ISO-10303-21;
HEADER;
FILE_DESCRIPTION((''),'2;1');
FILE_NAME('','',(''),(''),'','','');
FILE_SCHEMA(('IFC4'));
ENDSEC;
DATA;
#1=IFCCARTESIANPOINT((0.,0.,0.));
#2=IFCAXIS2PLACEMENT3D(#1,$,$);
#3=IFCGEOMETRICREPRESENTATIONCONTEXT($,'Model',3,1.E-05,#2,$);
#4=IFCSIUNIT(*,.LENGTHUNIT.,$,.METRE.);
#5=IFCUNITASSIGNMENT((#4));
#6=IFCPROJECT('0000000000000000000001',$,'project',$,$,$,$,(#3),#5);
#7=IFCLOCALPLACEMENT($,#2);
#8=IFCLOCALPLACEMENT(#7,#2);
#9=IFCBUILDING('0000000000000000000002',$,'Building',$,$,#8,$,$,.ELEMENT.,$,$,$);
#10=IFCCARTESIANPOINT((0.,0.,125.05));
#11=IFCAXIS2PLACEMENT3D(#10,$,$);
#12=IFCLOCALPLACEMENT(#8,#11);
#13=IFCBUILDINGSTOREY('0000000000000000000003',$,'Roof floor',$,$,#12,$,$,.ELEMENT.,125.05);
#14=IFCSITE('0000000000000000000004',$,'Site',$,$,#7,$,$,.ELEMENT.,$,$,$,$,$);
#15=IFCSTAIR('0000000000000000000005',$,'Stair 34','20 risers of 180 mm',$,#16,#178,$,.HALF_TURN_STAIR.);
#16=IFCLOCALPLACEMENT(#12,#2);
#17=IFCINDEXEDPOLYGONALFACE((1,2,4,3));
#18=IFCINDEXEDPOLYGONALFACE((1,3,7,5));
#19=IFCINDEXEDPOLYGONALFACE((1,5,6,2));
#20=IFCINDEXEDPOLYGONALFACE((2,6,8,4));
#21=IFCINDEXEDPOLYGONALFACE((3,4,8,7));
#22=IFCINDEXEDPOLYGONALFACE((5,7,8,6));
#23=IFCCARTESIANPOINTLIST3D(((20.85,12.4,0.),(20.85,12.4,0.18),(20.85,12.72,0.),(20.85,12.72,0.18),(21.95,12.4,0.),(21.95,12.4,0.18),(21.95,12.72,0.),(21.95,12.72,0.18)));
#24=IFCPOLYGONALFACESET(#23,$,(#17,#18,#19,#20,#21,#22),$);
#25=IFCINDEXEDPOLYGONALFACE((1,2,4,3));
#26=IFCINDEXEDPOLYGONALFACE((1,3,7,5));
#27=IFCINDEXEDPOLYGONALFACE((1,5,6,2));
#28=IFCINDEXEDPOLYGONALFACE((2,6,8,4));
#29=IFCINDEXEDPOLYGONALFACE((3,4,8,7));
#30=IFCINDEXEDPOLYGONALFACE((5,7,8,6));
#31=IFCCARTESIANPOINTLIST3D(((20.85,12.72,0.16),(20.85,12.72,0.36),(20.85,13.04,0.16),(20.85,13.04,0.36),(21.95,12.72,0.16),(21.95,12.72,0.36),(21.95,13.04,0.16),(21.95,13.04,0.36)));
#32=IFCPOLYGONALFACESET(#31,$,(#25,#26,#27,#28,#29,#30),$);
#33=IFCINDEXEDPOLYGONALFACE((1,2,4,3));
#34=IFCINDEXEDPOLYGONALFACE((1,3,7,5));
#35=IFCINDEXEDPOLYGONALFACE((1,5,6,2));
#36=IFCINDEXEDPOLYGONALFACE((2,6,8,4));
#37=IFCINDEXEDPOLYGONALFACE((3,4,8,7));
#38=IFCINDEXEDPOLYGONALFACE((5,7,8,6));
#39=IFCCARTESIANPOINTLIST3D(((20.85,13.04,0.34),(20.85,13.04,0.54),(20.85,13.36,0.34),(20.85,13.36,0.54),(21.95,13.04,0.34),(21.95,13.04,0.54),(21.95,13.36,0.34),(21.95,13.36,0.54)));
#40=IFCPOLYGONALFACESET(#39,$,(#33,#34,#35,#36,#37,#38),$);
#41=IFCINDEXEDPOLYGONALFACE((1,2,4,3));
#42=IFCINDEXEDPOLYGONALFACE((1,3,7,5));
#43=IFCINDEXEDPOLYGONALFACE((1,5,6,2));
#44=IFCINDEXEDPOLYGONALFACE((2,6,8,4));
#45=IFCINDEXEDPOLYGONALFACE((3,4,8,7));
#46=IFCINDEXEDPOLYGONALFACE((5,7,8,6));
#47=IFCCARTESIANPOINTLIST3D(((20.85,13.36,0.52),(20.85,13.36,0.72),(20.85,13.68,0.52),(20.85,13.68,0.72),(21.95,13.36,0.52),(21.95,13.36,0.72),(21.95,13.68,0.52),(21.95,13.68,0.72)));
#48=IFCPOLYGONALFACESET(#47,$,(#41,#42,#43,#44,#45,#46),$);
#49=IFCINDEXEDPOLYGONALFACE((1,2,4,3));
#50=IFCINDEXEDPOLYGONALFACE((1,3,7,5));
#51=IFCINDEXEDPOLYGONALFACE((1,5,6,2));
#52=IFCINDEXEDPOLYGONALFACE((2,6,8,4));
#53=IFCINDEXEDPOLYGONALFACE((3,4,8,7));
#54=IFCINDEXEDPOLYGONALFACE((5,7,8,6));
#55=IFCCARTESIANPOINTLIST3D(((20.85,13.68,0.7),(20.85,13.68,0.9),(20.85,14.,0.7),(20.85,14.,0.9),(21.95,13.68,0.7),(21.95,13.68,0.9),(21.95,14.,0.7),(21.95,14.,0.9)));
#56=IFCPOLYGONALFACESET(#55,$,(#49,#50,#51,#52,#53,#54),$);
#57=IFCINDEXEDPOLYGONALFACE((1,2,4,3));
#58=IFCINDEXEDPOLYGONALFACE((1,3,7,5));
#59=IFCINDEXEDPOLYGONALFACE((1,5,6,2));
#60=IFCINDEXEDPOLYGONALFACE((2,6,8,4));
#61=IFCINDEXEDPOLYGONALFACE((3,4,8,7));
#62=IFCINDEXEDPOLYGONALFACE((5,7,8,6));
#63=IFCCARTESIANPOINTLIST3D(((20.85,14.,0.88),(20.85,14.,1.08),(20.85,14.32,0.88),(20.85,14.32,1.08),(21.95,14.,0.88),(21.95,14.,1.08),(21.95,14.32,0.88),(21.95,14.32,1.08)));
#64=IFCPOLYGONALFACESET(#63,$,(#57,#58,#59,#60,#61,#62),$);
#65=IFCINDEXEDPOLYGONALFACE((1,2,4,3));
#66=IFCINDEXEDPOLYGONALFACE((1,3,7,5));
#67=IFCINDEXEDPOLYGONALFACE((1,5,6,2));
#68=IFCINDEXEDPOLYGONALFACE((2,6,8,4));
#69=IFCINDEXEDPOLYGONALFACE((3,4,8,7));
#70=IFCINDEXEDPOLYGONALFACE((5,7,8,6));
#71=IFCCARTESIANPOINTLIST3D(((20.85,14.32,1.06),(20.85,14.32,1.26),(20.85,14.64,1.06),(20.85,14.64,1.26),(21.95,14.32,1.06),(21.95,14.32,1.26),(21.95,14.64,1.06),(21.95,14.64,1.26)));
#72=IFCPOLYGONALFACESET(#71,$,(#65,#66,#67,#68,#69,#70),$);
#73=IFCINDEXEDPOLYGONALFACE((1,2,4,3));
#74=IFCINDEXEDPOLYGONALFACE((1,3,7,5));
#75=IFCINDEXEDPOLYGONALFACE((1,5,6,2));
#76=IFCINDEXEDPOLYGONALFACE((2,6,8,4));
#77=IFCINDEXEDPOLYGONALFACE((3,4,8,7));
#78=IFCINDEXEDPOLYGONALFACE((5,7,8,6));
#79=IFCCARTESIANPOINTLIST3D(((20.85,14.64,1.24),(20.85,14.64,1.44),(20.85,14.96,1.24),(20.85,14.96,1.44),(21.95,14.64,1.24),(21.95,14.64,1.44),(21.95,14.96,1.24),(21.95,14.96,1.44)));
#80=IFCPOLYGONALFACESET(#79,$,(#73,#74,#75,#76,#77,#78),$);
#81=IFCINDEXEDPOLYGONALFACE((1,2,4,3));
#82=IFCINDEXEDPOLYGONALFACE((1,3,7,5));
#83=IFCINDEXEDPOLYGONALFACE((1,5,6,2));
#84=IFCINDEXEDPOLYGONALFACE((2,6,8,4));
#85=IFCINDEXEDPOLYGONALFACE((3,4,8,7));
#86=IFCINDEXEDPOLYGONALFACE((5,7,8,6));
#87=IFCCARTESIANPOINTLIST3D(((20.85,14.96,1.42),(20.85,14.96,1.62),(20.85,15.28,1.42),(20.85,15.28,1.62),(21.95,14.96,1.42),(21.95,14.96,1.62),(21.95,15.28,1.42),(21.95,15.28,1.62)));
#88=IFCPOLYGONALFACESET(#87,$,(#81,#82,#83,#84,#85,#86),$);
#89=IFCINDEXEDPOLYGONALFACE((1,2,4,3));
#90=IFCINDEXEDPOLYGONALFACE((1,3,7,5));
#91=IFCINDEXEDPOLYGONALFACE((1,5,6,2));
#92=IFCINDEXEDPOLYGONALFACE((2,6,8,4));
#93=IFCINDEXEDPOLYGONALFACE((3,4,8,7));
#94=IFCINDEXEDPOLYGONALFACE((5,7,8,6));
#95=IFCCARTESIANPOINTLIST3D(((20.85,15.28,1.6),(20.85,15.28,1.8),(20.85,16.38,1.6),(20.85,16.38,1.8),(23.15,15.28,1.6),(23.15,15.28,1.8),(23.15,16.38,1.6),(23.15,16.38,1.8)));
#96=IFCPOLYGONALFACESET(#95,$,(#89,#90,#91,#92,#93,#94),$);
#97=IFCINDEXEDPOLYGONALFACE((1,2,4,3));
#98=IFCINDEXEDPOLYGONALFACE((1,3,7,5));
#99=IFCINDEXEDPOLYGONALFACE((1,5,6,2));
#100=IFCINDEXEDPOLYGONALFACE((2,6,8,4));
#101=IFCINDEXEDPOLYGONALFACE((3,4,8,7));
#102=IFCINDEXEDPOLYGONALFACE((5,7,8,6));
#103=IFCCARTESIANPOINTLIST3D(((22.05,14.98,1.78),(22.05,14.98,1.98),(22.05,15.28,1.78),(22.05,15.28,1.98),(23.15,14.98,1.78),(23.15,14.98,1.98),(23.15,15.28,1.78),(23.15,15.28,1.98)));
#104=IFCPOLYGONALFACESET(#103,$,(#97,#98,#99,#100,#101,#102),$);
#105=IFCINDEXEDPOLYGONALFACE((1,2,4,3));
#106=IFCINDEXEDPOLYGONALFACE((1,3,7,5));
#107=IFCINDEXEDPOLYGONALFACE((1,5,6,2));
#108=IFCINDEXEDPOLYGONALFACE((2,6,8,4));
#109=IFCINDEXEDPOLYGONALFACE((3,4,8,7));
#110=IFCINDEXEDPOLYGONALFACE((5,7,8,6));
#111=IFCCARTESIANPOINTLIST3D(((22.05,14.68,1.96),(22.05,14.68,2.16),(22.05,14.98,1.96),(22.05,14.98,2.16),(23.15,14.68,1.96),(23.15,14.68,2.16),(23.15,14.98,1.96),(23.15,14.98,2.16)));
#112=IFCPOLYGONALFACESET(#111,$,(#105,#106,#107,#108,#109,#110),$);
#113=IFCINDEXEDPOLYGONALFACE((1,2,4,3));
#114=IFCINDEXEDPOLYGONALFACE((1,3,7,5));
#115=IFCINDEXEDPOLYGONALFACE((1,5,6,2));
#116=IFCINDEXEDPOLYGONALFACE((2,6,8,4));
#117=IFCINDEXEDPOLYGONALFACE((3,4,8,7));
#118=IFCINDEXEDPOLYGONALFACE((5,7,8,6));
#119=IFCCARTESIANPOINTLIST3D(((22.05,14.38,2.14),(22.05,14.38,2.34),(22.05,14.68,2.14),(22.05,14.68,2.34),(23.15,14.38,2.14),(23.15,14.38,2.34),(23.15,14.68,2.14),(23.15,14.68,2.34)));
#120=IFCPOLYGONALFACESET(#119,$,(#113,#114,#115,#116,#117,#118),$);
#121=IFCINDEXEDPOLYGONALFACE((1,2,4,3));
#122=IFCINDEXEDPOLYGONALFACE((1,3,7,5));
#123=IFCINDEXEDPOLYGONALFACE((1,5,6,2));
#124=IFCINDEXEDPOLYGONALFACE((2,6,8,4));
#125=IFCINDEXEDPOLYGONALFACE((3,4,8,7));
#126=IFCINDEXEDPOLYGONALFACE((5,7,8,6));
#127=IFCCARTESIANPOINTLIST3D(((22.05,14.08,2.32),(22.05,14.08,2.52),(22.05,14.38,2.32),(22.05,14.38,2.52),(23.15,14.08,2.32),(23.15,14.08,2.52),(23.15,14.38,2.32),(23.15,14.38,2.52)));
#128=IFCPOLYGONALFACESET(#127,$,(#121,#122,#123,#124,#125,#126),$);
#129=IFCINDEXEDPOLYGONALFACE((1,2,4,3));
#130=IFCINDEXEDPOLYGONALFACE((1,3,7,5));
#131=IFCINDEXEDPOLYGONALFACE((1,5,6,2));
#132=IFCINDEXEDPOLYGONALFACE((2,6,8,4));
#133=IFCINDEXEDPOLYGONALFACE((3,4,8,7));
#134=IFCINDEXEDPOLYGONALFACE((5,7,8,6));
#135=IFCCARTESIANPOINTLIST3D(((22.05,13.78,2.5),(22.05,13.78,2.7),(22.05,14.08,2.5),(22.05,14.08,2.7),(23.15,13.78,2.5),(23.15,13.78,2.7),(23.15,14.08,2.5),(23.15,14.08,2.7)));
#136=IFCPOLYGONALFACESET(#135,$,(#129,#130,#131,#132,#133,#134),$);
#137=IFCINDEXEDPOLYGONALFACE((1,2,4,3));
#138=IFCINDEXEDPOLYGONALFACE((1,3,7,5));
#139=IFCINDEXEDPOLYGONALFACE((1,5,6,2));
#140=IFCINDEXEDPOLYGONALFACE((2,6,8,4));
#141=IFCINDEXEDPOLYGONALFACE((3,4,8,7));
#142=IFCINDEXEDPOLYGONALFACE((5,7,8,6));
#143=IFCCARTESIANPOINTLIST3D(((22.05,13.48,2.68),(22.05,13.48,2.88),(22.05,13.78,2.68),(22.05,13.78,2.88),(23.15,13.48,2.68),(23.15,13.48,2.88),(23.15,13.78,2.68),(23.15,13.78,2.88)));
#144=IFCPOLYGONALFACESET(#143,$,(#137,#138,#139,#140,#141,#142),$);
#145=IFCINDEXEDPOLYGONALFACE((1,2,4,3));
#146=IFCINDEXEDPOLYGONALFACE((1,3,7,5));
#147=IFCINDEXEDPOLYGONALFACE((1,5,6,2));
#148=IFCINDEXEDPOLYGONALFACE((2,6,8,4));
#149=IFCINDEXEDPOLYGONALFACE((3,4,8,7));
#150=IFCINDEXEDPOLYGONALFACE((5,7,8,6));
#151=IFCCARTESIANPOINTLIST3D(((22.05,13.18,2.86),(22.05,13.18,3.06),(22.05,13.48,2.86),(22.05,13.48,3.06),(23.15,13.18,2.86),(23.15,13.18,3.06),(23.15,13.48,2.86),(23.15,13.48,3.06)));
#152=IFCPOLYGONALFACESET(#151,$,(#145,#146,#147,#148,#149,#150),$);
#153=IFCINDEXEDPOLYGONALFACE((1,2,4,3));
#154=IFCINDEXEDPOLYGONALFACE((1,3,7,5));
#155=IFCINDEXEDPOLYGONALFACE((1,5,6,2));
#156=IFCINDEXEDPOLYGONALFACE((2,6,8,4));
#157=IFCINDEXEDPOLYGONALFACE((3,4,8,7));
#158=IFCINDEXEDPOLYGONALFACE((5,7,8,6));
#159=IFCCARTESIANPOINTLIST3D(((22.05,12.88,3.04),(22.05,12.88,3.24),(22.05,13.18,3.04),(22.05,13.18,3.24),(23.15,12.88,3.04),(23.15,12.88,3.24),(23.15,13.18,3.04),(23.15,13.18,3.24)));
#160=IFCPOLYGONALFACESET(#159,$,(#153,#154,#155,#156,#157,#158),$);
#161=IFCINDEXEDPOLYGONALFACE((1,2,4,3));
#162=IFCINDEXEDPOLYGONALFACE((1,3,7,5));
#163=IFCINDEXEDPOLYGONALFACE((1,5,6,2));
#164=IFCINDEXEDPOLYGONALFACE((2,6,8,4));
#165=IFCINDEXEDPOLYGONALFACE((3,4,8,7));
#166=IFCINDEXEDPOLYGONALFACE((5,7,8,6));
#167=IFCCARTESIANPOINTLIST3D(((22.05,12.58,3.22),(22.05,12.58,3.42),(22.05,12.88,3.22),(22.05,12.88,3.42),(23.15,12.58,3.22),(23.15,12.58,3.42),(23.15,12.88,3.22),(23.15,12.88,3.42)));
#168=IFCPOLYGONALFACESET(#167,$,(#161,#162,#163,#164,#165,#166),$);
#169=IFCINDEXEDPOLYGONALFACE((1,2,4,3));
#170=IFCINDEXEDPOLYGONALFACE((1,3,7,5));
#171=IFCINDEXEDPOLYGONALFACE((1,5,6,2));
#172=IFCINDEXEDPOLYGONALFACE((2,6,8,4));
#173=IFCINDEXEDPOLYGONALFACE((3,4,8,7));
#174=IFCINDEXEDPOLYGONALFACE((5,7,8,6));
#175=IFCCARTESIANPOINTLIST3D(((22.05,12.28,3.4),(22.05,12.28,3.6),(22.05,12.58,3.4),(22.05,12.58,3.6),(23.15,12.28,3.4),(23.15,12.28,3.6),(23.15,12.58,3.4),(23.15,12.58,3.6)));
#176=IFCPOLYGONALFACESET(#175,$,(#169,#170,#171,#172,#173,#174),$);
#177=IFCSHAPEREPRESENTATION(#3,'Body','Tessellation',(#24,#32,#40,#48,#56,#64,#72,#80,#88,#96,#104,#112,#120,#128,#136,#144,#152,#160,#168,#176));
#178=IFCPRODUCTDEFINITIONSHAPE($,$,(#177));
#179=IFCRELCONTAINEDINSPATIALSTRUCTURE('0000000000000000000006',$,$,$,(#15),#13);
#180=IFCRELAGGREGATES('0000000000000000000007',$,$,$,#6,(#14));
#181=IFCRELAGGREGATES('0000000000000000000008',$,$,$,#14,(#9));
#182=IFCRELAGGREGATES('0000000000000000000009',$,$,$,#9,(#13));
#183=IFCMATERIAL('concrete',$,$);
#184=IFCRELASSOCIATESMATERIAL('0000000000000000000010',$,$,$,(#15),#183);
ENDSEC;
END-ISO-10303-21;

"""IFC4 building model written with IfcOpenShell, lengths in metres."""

from ifc_helpers import new_model, si_unit, frame, origin, place, context, project, spatial, polyline, outline, extrude, material, element, save


model = new_model("IFC4")

# Units and contexts
model_context = context("Model", 3, precision=1e-05, world=origin())
ifc_project = project(units=[si_unit("LENGTHUNIT", "METRE")], contexts=[model_context])

# Site, building, storey
site_placement = place(None, origin())
site = spatial("IfcSite", under=ifc_project, at=site_placement, Name="Site", CompositionType="ELEMENT")
building_placement = place(site_placement, origin())
building = spatial("IfcBuilding", under=site, at=building_placement, Name="Building", CompositionType="ELEMENT")
storey_placement = place(building_placement, frame((0.0, 0.0, 125.05)))
storey = spatial("IfcBuildingStorey", under=building, at=storey_placement, Name="Roof floor", CompositionType="ELEMENT", Elevation=125.05)

# Shared definitions
ifc_material = material(Name="concrete")

# Stair
stair_1_placement = place(storey_placement, frame((21.4, 12.4, 0.0), z_axis=(0.0, 0.0, 1.0), x_axis=(0.0, 1.0, 0.0)))
element("IfcStair", 1, at=stair_1_placement, inside=storey, material=ifc_material, Name="Stair 34", Description="20 risers of 180 mm", PredefinedType="HALF_TURN_STAIR", context=model_context, shape_type="SweptSolid", body=[
    extrude(outline(polyline([(0.0, -0.55), (0.32, -0.55), (0.32, 0.55), (0.0, 0.55), (0.0, -0.55)])), origin(), (0.0, 0.0, 1.0), 0.18),
    extrude(outline(polyline([(0.32, -0.55), (0.64, -0.55), (0.64, 0.55), (0.32, 0.55), (0.32, -0.55)])), frame((0.0, 0.0, 0.16)), (0.0, 0.0, 1.0), 0.2),
    extrude(outline(polyline([(0.64, -0.55), (0.96, -0.55), (0.96, 0.55), (0.64, 0.55), (0.64, -0.55)])), frame((0.0, 0.0, 0.34)), (0.0, 0.0, 1.0), 0.2),
    extrude(outline(polyline([(0.96, -0.55), (1.28, -0.55), (1.28, 0.55), (0.96, 0.55), (0.96, -0.55)])), frame((0.0, 0.0, 0.52)), (0.0, 0.0, 1.0), 0.2),
    extrude(outline(polyline([(1.28, -0.55), (1.6, -0.55), (1.6, 0.55), (1.28, 0.55), (1.28, -0.55)])), frame((0.0, 0.0, 0.7)), (0.0, 0.0, 1.0), 0.2),
    extrude(outline(polyline([(1.6, -0.55), (1.92, -0.55), (1.92, 0.55), (1.6, 0.55), (1.6, -0.55)])), frame((0.0, 0.0, 0.88)), (0.0, 0.0, 1.0), 0.2),
    extrude(outline(polyline([(1.92, -0.55), (2.24, -0.55), (2.24, 0.55), (1.92, 0.55), (1.92, -0.55)])), frame((0.0, 0.0, 1.06)), (0.0, 0.0, 1.0), 0.2),
    extrude(outline(polyline([(2.24, -0.55), (2.56, -0.55), (2.56, 0.55), (2.24, 0.55), (2.24, -0.55)])), frame((0.0, 0.0, 1.24)), (0.0, 0.0, 1.0), 0.2),
    extrude(outline(polyline([(2.56, -0.55), (2.88, -0.55), (2.88, 0.55), (2.56, 0.55), (2.56, -0.55)])), frame((0.0, 0.0, 1.42)), (0.0, 0.0, 1.0), 0.2),
    extrude(outline(polyline([(2.88, -1.75), (3.98, -1.75), (3.98, 0.55), (2.88, 0.55), (2.88, -1.75)])), frame((0.0, 0.0, 1.6)), (0.0, 0.0, 1.0), 0.2),
    extrude(outline(polyline([(2.58, -1.75), (2.88, -1.75), (2.88, -0.65), (2.58, -0.65), (2.58, -1.75)])), frame((0.0, 0.0, 1.78)), (0.0, 0.0, 1.0), 0.2),
    extrude(outline(polyline([(2.28, -1.75), (2.58, -1.75), (2.58, -0.65), (2.28, -0.65), (2.28, -1.75)])), frame((0.0, 0.0, 1.96)), (0.0, 0.0, 1.0), 0.2),
    extrude(outline(polyline([(1.98, -1.75), (2.28, -1.75), (2.28, -0.65), (1.98, -0.65), (1.98, -1.75)])), frame((0.0, 0.0, 2.14)), (0.0, 0.0, 1.0), 0.2),
    extrude(outline(polyline([(1.68, -1.75), (1.98, -1.75), (1.98, -0.65), (1.68, -0.65), (1.68, -1.75)])), frame((0.0, 0.0, 2.32)), (0.0, 0.0, 1.0), 0.2),
    extrude(outline(polyline([(1.38, -1.75), (1.68, -1.75), (1.68, -0.65), (1.38, -0.65), (1.38, -1.75)])), frame((0.0, 0.0, 2.5)), (0.0, 0.0, 1.0), 0.2),
    extrude(outline(polyline([(1.08, -1.75), (1.38, -1.75), (1.38, -0.65), (1.08, -0.65), (1.08, -1.75)])), frame((0.0, 0.0, 2.68)), (0.0, 0.0, 1.0), 0.2),
    extrude(outline(polyline([(0.78, -1.75), (1.08, -1.75), (1.08, -0.65), (0.78, -0.65), (0.78, -1.75)])), frame((0.0, 0.0, 2.86)), (0.0, 0.0, 1.0), 0.2),
    extrude(outline(polyline([(0.48, -1.75), (0.78, -1.75), (0.78, -0.65), (0.48, -0.65), (0.48, -1.75)])), frame((0.0, 0.0, 3.04)), (0.0, 0.0, 1.0), 0.2),
    extrude(outline(polyline([(0.18, -1.75), (0.48, -1.75), (0.48, -0.65), (0.18, -0.65), (0.18, -1.75)])), frame((0.0, 0.0, 3.22)), (0.0, 0.0, 1.0), 0.2),
    extrude(outline(polyline([(-0.12, -1.75), (0.18, -1.75), (0.18, -0.65), (-0.12, -0.65), (-0.12, -1.75)])), frame((0.0, 0.0, 3.4)), (0.0, 0.0, 1.0), 0.2),
])

save(model, "model.ifc")
